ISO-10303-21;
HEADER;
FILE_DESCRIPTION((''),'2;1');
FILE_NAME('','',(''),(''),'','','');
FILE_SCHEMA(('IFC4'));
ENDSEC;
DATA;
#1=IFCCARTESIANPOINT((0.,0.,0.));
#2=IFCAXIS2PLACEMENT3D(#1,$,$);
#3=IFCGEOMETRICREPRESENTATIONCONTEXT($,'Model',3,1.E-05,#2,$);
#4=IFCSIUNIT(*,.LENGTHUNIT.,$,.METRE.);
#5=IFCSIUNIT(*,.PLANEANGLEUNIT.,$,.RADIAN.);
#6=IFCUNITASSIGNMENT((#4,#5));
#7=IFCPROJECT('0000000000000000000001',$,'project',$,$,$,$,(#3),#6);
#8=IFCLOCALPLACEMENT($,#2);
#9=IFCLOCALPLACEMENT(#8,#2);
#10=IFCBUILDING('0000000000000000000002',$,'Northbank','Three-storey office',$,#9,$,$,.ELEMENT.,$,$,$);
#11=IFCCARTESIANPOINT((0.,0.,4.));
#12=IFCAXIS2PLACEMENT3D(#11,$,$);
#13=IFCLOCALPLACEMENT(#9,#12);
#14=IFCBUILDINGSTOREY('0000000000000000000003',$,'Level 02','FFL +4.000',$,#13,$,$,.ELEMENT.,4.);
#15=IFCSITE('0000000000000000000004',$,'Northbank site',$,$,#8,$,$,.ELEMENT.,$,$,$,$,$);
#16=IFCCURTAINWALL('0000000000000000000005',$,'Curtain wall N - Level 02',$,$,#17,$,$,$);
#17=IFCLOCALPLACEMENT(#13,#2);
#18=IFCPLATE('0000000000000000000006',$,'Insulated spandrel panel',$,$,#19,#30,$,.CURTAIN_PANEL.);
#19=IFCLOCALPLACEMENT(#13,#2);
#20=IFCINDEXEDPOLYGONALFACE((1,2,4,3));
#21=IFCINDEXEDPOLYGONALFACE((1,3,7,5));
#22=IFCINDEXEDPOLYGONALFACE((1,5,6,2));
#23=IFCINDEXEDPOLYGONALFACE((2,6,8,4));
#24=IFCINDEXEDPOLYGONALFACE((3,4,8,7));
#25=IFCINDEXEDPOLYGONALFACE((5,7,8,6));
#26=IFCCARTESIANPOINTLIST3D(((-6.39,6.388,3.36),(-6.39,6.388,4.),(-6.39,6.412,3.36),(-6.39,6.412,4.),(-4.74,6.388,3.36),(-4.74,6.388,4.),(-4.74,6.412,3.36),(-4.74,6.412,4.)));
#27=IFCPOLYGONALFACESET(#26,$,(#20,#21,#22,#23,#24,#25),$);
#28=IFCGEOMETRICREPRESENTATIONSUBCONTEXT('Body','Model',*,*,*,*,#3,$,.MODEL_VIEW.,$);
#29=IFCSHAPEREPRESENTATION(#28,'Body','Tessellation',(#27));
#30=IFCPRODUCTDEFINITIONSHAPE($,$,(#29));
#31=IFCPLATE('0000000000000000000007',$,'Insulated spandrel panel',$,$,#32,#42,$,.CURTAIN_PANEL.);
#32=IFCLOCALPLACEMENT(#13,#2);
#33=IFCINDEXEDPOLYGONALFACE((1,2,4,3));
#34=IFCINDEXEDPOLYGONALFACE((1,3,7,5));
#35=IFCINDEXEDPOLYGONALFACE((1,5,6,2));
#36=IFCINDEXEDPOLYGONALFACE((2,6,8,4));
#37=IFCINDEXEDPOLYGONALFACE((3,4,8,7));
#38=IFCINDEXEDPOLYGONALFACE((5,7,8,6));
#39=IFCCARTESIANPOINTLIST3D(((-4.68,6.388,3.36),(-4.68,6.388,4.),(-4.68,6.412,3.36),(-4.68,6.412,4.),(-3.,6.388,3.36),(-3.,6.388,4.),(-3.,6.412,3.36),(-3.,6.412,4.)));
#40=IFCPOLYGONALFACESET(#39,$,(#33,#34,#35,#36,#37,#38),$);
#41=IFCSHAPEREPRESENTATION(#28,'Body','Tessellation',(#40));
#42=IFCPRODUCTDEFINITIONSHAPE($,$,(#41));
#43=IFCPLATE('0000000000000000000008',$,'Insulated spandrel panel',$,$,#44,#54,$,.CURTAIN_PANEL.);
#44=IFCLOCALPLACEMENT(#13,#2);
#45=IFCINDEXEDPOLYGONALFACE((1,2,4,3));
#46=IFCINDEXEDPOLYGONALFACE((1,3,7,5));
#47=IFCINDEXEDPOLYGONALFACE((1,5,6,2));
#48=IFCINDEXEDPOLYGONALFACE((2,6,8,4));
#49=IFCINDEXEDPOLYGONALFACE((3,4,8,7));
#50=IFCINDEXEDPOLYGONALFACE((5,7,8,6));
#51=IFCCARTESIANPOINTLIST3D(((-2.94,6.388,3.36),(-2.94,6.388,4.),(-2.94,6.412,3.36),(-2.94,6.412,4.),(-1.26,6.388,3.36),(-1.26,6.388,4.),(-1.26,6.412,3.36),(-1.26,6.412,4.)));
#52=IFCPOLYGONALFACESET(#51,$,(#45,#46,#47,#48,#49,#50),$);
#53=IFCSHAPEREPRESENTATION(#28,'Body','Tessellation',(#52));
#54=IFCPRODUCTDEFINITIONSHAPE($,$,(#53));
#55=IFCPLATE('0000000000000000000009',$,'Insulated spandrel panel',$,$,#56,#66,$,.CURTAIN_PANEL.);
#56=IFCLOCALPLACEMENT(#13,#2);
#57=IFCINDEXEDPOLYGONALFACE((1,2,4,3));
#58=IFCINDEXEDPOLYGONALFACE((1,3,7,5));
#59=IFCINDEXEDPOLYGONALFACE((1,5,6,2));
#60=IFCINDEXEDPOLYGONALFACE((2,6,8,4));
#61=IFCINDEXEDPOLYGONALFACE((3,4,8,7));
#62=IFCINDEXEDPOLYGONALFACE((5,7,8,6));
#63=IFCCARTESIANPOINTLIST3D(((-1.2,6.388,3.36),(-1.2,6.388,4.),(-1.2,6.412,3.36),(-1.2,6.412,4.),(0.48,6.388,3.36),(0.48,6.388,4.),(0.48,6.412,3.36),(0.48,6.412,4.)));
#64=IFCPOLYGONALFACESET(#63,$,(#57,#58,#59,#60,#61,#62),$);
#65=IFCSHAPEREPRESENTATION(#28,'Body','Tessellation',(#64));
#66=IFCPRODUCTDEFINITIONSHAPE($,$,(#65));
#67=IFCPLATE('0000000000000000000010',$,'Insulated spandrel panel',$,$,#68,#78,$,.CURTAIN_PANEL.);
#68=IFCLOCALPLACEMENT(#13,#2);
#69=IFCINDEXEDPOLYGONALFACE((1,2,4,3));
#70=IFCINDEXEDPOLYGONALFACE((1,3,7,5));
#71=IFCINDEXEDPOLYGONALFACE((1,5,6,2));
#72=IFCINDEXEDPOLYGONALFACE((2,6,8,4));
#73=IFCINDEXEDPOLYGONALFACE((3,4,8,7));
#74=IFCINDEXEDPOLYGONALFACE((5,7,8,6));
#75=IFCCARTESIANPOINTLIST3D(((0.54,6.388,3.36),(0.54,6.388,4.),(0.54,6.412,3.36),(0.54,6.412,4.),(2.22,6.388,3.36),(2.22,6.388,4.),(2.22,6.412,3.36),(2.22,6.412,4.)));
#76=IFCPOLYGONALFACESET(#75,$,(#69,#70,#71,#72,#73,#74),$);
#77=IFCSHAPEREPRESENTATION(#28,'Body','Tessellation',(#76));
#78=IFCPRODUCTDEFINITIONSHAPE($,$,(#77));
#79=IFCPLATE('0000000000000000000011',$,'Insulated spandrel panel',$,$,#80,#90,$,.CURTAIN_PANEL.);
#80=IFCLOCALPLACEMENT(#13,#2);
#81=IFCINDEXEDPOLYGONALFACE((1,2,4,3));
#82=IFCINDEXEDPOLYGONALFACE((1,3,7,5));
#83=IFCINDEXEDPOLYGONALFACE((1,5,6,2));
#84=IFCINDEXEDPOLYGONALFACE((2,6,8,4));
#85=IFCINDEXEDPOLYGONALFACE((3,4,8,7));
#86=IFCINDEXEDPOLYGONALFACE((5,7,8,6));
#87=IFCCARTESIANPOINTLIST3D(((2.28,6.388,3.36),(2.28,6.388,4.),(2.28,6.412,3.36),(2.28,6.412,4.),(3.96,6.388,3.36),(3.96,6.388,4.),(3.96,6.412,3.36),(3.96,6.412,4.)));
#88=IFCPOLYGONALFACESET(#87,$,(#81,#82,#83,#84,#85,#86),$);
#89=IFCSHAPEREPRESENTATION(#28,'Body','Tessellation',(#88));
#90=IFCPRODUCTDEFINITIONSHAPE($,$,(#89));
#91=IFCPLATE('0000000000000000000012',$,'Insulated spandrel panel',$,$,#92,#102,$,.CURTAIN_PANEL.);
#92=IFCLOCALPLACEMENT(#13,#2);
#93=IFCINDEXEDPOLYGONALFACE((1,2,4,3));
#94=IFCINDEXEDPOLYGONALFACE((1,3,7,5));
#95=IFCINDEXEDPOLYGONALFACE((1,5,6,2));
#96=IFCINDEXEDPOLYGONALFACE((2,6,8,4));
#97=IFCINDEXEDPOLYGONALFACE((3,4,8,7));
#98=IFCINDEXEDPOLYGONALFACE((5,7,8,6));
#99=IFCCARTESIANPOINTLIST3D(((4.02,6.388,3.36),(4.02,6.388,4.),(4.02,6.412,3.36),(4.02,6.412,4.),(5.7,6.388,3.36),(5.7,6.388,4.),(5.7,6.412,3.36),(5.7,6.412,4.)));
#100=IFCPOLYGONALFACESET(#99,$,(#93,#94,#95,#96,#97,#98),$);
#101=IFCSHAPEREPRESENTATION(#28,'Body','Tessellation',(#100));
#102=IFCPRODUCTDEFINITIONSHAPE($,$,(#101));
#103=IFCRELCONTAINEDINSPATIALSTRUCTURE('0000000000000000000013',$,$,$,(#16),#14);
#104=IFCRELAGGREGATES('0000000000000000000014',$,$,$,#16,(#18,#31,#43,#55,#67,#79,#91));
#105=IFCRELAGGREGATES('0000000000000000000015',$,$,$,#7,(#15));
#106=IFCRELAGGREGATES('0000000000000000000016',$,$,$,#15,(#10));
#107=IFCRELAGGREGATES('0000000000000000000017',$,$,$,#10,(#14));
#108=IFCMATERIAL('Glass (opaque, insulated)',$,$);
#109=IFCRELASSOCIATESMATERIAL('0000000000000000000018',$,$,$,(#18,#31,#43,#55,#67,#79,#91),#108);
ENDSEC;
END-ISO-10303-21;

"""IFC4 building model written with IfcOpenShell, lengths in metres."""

from ifc_helpers import new_model, si_unit, frame, origin, place, context, subcontext, project, spatial, rectangle, extrude, material, element, aggregate, save


model = new_model("IFC4")

# Units and contexts
model_context = context("Model", 3, precision=1e-05, world=origin())
body_context = subcontext(model_context, "Body", "Model", "MODEL_VIEW")
ifc_project = project(units=[si_unit("LENGTHUNIT", "METRE"), si_unit("PLANEANGLEUNIT", "RADIAN")], contexts=[model_context])

# Site, building, storey
site_placement = place(None, origin())
site = spatial("IfcSite", under=ifc_project, at=site_placement, Name="Northbank site", CompositionType="ELEMENT")
building_placement = place(site_placement, origin())
building = spatial("IfcBuilding", under=site, at=building_placement, Name="Northbank", Description="Three-storey office", CompositionType="ELEMENT")
storey_placement = place(building_placement, frame((0.0, 0.0, 4.0)))
storey = spatial("IfcBuildingStorey", under=building, at=storey_placement, Name="Level 02", Description="FFL +4.000", CompositionType="ELEMENT", Elevation=4.0)

# Curtain wall, plates
curtain_wall_placement = place(storey_placement, frame((0.0, 0.0, -4.0)))
curtain_wall = element("IfcCurtainWall", 1, at=curtain_wall_placement, inside=storey, Name="Curtain wall N - Level 02")
ifc_material_1 = material(Name="Glass (opaque, insulated)")
plate_1_placement = place(storey_placement, frame((0.0, 0.0, -4.0)))
plate_1 = element("IfcPlate", 2, at=plate_1_placement, material=ifc_material_1, Name="Insulated spandrel panel", PredefinedType="CURTAIN_PANEL", context=body_context, shape_type="SweptSolid", body=[
    extrude(rectangle(XDim=1.65, YDim=0.024), frame((-5.565, 6.4, 7.36)), (0.0, 0.0, 1.0), 0.64),
])
plate_2_placement = place(storey_placement, frame((0.0, 0.0, -4.0)))
plate_2 = element("IfcPlate", 3, at=plate_2_placement, material=ifc_material_1, Name="Insulated spandrel panel", PredefinedType="CURTAIN_PANEL", context=body_context, shape_type="SweptSolid", body=[
    extrude(rectangle(XDim=1.68, YDim=0.024), frame((-3.84, 6.4, 7.36)), (0.0, 0.0, 1.0), 0.64),
])
plate_3_placement = place(storey_placement, frame((0.0, 0.0, -4.0)))
plate_3 = element("IfcPlate", 4, at=plate_3_placement, material=ifc_material_1, Name="Insulated spandrel panel", PredefinedType="CURTAIN_PANEL", context=body_context, shape_type="SweptSolid", body=[
    extrude(rectangle(XDim=1.68, YDim=0.024), frame((-2.1, 6.4, 7.36)), (0.0, 0.0, 1.0), 0.64),
])
plate_4_placement = place(storey_placement, frame((0.0, 0.0, -4.0)))
plate_4 = element("IfcPlate", 5, at=plate_4_placement, material=ifc_material_1, Name="Insulated spandrel panel", PredefinedType="CURTAIN_PANEL", context=body_context, shape_type="SweptSolid", body=[
    extrude(rectangle(XDim=1.68, YDim=0.024), frame((-0.36, 6.4, 7.36)), (0.0, 0.0, 1.0), 0.64),
])
plate_5_placement = place(storey_placement, frame((0.0, 0.0, -4.0)))
plate_5 = element("IfcPlate", 6, at=plate_5_placement, material=ifc_material_1, Name="Insulated spandrel panel", PredefinedType="CURTAIN_PANEL", context=body_context, shape_type="SweptSolid", body=[
    extrude(rectangle(XDim=1.68, YDim=0.024), frame((1.38, 6.4, 7.36)), (0.0, 0.0, 1.0), 0.64),
])
plate_6_placement = place(storey_placement, frame((0.0, 0.0, -4.0)))
plate_6 = element("IfcPlate", 7, at=plate_6_placement, material=ifc_material_1, Name="Insulated spandrel panel", PredefinedType="CURTAIN_PANEL", context=body_context, shape_type="SweptSolid", body=[
    extrude(rectangle(XDim=1.68, YDim=0.024), frame((3.12, 6.4, 7.36)), (0.0, 0.0, 1.0), 0.64),
])
plate_7_placement = place(storey_placement, frame((0.0, 0.0, -4.0)))
plate_7 = element("IfcPlate", 8, at=plate_7_placement, material=ifc_material_1, Name="Insulated spandrel panel", PredefinedType="CURTAIN_PANEL", context=body_context, shape_type="SweptSolid", body=[
    extrude(rectangle(XDim=1.68, YDim=0.024), frame((4.86, 6.4, 7.36)), (0.0, 0.0, 1.0), 0.64),
])
aggregate(curtain_wall, [plate_1, plate_2, plate_3, plate_4, plate_5, plate_6, plate_7])

save(model, "model.ifc")
